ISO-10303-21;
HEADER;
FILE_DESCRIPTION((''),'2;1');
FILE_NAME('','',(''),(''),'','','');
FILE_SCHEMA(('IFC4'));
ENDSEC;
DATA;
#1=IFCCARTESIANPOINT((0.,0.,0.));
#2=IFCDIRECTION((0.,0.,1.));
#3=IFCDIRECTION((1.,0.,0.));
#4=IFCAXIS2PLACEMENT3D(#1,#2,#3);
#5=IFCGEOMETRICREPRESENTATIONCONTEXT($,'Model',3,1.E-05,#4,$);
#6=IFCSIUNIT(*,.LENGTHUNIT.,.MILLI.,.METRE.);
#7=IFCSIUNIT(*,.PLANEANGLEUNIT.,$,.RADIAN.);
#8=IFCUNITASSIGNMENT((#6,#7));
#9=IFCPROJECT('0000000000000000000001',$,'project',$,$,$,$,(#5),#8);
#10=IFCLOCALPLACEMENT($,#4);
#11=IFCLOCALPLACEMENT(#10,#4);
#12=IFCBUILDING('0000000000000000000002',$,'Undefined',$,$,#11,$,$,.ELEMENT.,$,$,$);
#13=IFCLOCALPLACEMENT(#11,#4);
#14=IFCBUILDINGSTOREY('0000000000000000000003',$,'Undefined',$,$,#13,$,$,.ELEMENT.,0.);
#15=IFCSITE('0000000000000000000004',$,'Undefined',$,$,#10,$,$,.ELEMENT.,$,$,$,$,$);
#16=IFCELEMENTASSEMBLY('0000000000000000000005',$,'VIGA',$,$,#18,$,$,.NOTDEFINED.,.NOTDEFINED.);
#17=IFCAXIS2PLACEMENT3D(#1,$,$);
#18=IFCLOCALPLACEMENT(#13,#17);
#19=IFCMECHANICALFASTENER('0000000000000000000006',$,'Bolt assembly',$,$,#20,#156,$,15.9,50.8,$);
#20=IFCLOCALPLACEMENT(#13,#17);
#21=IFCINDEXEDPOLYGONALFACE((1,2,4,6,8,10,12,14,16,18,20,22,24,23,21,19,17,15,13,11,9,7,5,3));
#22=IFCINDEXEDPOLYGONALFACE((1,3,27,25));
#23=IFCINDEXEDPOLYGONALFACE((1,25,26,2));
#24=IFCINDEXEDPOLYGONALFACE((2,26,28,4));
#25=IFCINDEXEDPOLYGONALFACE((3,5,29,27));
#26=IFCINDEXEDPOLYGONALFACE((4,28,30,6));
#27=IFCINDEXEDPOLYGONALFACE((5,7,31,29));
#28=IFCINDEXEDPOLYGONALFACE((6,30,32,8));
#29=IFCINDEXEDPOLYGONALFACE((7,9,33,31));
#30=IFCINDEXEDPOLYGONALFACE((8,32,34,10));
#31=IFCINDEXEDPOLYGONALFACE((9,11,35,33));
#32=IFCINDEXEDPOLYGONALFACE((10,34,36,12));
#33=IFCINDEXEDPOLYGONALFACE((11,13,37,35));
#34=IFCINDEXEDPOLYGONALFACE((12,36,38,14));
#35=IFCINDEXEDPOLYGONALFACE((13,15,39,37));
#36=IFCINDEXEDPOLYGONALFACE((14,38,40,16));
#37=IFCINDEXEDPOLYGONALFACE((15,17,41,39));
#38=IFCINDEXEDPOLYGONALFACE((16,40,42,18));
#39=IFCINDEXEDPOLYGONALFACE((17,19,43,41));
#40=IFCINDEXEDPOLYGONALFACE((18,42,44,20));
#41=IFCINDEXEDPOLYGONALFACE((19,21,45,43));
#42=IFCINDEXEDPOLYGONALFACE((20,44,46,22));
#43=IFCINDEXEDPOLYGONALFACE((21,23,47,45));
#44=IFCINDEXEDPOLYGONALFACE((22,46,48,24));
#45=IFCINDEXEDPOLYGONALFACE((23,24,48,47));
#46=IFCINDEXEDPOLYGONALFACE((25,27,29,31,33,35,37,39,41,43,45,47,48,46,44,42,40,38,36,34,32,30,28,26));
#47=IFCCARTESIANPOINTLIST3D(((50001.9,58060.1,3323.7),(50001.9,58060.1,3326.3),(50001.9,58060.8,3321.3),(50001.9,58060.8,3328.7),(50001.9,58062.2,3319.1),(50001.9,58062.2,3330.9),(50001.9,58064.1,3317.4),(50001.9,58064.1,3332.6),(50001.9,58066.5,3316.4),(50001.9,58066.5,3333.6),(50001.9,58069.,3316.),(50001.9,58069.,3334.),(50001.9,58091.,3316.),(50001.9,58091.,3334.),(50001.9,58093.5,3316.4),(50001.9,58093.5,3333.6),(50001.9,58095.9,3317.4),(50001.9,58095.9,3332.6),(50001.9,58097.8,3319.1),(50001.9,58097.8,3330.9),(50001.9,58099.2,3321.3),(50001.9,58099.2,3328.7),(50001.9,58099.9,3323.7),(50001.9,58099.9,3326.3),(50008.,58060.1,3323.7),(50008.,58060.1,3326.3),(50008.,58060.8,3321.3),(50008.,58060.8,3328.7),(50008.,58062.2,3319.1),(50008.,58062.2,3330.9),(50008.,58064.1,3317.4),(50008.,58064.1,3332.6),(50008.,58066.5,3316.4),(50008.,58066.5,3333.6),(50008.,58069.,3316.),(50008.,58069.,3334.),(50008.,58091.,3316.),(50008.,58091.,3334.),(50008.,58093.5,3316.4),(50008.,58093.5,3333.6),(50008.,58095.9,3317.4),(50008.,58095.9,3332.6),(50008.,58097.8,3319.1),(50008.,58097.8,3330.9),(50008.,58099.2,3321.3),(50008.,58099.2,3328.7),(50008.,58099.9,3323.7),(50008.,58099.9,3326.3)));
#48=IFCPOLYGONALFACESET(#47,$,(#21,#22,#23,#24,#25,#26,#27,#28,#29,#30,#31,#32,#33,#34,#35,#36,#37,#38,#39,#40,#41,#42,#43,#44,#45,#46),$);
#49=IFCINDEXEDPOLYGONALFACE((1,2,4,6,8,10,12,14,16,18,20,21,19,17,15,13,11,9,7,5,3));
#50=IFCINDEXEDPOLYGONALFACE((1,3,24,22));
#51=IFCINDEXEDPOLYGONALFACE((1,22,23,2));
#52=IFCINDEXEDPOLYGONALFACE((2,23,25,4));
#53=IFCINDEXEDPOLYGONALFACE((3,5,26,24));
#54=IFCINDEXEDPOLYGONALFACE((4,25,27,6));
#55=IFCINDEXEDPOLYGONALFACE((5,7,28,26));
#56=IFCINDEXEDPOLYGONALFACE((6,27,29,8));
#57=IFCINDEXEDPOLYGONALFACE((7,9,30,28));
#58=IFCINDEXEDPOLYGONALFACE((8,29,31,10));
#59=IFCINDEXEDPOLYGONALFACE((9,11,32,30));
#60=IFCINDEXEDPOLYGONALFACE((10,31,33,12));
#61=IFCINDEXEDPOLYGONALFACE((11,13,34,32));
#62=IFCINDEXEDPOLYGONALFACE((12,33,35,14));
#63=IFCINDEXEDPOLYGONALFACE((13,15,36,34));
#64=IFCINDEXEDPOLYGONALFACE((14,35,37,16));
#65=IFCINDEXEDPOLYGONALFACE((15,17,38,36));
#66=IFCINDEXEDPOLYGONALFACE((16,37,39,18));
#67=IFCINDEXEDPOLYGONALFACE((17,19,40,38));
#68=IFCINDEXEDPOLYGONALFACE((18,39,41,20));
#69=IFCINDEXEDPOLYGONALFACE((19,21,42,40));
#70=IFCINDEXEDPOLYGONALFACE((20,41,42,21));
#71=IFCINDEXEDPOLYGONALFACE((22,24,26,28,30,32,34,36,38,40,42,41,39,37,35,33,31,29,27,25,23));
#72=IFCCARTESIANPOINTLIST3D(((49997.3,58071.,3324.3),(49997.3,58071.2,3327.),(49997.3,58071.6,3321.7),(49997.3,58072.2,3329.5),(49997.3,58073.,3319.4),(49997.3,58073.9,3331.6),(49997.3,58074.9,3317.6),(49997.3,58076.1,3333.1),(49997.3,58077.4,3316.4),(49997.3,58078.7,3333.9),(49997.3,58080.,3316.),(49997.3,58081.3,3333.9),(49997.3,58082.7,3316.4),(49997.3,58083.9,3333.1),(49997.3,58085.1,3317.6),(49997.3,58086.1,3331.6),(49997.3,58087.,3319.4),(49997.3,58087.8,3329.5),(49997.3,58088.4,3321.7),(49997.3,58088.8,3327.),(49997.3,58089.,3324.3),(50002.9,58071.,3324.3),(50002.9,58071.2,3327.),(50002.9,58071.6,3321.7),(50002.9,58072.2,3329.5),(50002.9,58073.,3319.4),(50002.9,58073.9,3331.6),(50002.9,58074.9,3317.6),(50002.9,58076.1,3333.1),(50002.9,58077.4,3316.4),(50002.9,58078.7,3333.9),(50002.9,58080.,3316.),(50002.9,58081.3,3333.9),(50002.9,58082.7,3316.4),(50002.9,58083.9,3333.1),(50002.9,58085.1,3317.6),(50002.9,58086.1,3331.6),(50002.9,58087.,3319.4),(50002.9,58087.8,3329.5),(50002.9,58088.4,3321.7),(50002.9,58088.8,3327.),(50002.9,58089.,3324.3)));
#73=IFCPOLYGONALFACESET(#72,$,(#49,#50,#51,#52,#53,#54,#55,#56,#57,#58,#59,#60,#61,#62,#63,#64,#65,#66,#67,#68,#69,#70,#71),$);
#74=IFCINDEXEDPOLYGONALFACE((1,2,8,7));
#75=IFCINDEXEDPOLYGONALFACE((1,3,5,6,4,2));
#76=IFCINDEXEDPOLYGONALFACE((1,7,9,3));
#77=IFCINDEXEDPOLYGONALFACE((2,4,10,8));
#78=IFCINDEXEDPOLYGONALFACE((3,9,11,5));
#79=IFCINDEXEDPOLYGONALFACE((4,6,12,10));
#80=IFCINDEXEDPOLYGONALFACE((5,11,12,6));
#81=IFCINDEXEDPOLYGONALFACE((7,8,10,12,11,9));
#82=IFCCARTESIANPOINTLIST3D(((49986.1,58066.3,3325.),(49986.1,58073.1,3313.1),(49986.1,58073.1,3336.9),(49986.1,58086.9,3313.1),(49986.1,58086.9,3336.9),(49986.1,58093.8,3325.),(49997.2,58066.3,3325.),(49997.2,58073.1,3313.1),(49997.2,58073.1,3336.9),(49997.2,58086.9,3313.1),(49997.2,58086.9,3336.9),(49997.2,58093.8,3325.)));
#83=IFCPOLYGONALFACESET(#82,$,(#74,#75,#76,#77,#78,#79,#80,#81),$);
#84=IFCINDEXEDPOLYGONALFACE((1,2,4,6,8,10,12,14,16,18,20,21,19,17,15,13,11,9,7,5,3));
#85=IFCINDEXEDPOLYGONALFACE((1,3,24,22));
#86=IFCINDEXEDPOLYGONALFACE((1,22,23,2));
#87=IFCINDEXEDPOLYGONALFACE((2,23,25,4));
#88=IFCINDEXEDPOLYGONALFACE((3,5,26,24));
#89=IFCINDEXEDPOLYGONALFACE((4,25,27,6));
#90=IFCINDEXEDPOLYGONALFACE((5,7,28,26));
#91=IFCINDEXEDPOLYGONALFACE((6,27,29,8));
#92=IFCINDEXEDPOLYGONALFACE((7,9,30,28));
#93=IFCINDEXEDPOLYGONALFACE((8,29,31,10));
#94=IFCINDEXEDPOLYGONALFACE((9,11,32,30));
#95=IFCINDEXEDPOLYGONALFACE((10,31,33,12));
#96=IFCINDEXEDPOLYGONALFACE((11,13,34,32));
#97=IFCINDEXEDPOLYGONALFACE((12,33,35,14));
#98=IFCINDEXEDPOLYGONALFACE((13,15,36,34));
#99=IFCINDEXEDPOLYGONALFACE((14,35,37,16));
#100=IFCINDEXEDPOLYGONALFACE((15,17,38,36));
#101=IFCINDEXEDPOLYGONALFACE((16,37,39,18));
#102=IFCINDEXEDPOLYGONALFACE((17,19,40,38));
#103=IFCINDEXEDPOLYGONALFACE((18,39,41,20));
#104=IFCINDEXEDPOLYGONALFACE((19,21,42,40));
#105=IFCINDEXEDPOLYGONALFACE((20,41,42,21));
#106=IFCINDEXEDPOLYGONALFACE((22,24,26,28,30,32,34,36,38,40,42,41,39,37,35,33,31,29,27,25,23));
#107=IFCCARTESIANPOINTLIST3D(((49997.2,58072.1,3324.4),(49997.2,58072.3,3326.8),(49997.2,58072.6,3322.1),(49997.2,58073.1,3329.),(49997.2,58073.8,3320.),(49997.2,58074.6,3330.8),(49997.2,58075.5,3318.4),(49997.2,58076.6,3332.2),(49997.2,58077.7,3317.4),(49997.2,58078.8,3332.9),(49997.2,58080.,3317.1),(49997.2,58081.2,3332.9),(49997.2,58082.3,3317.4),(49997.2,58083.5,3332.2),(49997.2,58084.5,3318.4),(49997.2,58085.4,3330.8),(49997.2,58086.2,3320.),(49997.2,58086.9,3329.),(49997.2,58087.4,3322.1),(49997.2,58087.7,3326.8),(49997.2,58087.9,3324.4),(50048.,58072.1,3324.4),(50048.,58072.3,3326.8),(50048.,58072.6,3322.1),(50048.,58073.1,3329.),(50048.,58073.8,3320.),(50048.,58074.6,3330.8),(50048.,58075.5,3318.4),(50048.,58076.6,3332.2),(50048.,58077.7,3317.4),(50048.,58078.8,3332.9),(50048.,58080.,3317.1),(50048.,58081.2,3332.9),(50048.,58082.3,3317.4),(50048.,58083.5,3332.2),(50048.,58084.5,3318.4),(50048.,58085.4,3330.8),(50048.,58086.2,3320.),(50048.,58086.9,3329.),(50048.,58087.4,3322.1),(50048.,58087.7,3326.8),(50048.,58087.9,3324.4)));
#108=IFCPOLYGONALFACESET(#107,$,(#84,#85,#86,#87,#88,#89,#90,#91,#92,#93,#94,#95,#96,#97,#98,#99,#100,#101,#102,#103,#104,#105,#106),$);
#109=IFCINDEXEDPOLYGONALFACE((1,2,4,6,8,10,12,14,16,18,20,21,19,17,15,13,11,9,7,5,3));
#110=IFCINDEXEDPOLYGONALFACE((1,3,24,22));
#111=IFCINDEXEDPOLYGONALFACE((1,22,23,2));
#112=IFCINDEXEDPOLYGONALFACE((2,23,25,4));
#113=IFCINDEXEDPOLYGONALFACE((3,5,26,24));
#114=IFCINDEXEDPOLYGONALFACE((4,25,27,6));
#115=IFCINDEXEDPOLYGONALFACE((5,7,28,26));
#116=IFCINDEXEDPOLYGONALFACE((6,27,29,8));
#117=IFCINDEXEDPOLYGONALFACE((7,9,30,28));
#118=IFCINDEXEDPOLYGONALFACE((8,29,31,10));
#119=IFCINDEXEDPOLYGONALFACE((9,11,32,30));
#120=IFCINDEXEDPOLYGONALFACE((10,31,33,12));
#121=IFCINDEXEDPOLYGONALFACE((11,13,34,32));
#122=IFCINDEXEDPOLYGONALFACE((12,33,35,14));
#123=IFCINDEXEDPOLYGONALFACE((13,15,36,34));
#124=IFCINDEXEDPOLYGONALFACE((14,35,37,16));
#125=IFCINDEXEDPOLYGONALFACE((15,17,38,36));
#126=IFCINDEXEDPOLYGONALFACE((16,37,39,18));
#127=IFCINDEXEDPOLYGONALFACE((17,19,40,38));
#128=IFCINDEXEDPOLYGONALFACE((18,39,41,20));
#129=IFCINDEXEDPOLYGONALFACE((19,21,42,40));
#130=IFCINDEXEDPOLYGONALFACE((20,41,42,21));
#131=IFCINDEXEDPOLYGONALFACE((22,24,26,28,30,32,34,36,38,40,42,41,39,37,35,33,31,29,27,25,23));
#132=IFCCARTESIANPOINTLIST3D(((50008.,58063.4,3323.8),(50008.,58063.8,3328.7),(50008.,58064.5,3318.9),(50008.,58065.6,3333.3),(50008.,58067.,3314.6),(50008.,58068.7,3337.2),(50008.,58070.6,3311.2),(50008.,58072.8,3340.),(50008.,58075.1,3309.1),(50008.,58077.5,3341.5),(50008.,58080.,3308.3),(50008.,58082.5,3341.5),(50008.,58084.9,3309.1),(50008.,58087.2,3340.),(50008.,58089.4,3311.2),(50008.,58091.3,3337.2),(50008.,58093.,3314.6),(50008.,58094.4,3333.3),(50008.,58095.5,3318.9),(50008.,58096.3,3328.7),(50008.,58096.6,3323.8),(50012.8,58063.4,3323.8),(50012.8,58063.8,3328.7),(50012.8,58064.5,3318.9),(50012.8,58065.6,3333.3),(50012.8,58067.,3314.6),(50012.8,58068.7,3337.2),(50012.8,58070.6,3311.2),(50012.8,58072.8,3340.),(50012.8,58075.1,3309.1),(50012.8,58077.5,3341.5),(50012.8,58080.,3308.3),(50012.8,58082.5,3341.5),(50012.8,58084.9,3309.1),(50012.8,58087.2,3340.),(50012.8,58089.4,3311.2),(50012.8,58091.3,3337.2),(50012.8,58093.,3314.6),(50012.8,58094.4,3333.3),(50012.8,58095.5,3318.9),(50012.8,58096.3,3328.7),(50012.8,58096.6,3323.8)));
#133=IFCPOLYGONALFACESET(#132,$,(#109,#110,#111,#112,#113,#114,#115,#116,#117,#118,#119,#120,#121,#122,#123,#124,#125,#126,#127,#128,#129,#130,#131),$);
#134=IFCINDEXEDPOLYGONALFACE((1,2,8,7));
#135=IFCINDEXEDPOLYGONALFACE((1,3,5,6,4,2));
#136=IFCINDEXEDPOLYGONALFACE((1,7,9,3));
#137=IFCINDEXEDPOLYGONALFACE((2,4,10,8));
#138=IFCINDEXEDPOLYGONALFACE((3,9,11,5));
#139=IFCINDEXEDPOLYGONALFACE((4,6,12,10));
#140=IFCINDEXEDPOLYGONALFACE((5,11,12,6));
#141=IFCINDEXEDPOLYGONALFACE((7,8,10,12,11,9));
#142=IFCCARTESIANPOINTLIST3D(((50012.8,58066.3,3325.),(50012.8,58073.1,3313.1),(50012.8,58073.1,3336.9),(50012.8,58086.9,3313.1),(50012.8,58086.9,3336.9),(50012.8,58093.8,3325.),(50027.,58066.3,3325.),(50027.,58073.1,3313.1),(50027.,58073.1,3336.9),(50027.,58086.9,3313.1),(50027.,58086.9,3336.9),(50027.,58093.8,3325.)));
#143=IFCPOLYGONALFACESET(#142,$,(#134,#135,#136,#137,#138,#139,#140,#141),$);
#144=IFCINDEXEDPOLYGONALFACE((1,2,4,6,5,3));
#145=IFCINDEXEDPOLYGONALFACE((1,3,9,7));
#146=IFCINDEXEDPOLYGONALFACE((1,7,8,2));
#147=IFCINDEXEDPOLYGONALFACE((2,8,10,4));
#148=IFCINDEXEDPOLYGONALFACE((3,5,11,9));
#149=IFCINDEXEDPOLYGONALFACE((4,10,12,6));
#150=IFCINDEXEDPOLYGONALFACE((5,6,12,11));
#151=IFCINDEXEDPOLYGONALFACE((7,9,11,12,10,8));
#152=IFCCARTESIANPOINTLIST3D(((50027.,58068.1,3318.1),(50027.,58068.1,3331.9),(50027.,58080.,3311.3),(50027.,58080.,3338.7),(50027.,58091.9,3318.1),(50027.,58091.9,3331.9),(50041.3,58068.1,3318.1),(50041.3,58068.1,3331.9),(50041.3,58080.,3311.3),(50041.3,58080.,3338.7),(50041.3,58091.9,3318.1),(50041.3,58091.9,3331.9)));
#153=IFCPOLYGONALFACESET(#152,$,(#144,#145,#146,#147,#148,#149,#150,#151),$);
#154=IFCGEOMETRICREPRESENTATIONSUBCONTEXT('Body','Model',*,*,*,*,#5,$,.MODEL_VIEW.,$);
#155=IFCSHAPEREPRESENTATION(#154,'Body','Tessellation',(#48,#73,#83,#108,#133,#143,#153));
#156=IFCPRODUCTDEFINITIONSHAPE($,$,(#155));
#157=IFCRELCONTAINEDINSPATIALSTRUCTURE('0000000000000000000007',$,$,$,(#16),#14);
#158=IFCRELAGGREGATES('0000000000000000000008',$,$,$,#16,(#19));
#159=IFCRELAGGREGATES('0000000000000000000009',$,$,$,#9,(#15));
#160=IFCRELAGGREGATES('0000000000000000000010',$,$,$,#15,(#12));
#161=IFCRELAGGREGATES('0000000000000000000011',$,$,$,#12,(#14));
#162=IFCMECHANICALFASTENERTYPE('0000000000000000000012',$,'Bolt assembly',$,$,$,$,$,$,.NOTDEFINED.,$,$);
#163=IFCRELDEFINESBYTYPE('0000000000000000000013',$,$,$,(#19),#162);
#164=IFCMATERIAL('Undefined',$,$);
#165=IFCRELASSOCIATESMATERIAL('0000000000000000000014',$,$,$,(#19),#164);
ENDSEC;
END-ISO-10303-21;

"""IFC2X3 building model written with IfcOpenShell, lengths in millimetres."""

from ifc_helpers import new_model, si_unit, frame, frame_2d, origin_with_axes, origin_2d_with_axis, place, context, subcontext, project, spatial, polyline, circle_curve, parameter, trimmed, segment, composite_curve, circle, outline, extrude, source, transform, mapped, material, type_object, element, aggregate, save


model = new_model("IFC2X3")

# Units and contexts
model_context = context("Model", 3, precision=1e-05, world=origin_with_axes())
body_context = subcontext(model_context, "Body", "Model", "MODEL_VIEW")
ifc_project = project(units=[si_unit("LENGTHUNIT", "METRE", prefix="MILLI"), si_unit("PLANEANGLEUNIT", "RADIAN")], contexts=[model_context])

# Site, building, storey
site_placement = place(None, origin_with_axes())
site = spatial("IfcSite", under=ifc_project, at=site_placement, Name="Undefined", CompositionType="ELEMENT")
building_placement = place(site_placement, origin_with_axes())
building = spatial("IfcBuilding", under=site, at=building_placement, Name="Undefined", CompositionType="ELEMENT")
storey_placement = place(building_placement, origin_with_axes())
storey = spatial("IfcBuildingStorey", under=building, at=storey_placement, Name="Undefined", CompositionType="ELEMENT", Elevation=0.0)

# Element assembly
assembly_1_placement = place(storey_placement, origin_with_axes())
assembly_1 = element("IfcElementAssembly", 1, at=assembly_1_placement, inside=storey, Name="VIGA", AssemblyPlace="NOTDEFINED", PredefinedType="NOTDEFINED")

# Shared definitions
ifc_material_1 = material(Name="Undefined")
mechanical_fastener_type = type_object("IfcMechanicalFastenerType", Name="Bolt assembly")

# Mechanical fastener
shared_shape_1 = source(origin_with_axes(), body_context, "Body", "SweptSolid", [
    extrude(outline(composite_curve([segment(polyline([(9.0, 11.0), (9.0, -11.0)]), True, "CONTINUOUS"), segment(trimmed(circle_curve(frame_2d((0.0, -11.0), x_axis=(1.0, 0.0)), 9.0), [parameter(0.0)], [parameter(3.141593)], False, "PARAMETER"), True, "CONTINUOUS"), segment(polyline([(-9.0, -11.0), (-9.0, 11.0)]), True, "CONTINUOUS"), segment(trimmed(circle_curve(frame_2d((0.0, 11.0), x_axis=(-1.0, 0.0)), 9.0), [parameter(0.0)], [parameter(3.141593)], False, "PARAMETER"), True, "DISCONTINUOUS")], self_intersect=False)), frame((0.0, 1.9, 0.0), z_axis=(0.0, 1.0, 0.0), x_axis=(1.0, 0.0, 0.0)), (0.0, 0.0, 1.0), 6.1),
    extrude(circle(Radius=9.0, at=origin_2d_with_axis()), frame((0.0, -2.7, 0.0), z_axis=(0.0, 1.0, 0.0), x_axis=(1.0, 0.0, 0.0)), (0.0, 0.0, 1.0), 5.6),
    extrude(outline(polyline([(11.9, -6.9), (11.9, 6.9), (0.0, 13.7), (-11.9, 6.9), (-11.9, -6.9), (0.0, -13.7), (11.9, -6.9)])), frame((0.0, -13.9, 0.0), z_axis=(0.0, 1.0, 0.0), x_axis=(1.0, 0.0, 0.0)), (0.0, 0.0, 1.0), 11.1),
    extrude(circle(Radius=7.9, at=origin_2d_with_axis()), frame((0.0, -2.8, 0.0), z_axis=(0.0, 1.0, 0.0), x_axis=(1.0, 0.0, 0.0)), (0.0, 0.0, 1.0), 50.8),
    extrude(circle(Radius=16.7, at=origin_2d_with_axis()), frame((0.0, 8.0, 0.0), z_axis=(0.0, 1.0, 0.0), x_axis=(1.0, 0.0, 0.0)), (0.0, 0.0, 1.0), 4.8),
    extrude(outline(polyline([(11.9, -6.9), (11.9, 6.9), (0.0, 13.7), (-11.9, 6.9), (-11.9, -6.9), (0.0, -13.7), (11.9, -6.9)])), frame((0.0, 12.8, 0.0), z_axis=(0.0, 1.0, 0.0), x_axis=(1.0, 0.0, 0.0)), (0.0, 0.0, 1.0), 14.3),
    extrude(outline(polyline([(13.7, 0.0), (6.9, 11.9), (-6.9, 11.9), (-13.7, 0.0), (-6.9, -11.9), (6.9, -11.9), (13.7, 0.0)])), frame((0.0, 27.0, 0.0), z_axis=(0.0, 1.0, 0.0), x_axis=(1.0, 0.0, 0.0)), (0.0, 0.0, 1.0), 14.3),
])
mechanical_fastener_1_placement = place(assembly_1_placement, frame((50000.0, 58080.0, 3325.0), z_axis=(0.0, -1.0, 0.0), x_axis=(0.0, 0.0, -1.0)))
mechanical_fastener_1 = element("IfcMechanicalFastener", 2, at=mechanical_fastener_1_placement, type_object=mechanical_fastener_type, material=ifc_material_1, Name="Bolt assembly", NominalDiameter=15.9, NominalLength=50.8, context=body_context, shape_type="MappedRepresentation", body=[
    mapped(shared_shape_1, transform((0.0, 0.0, 0.0))),
])
aggregate(assembly_1, [mechanical_fastener_1])

save(model, "model.ifc")
